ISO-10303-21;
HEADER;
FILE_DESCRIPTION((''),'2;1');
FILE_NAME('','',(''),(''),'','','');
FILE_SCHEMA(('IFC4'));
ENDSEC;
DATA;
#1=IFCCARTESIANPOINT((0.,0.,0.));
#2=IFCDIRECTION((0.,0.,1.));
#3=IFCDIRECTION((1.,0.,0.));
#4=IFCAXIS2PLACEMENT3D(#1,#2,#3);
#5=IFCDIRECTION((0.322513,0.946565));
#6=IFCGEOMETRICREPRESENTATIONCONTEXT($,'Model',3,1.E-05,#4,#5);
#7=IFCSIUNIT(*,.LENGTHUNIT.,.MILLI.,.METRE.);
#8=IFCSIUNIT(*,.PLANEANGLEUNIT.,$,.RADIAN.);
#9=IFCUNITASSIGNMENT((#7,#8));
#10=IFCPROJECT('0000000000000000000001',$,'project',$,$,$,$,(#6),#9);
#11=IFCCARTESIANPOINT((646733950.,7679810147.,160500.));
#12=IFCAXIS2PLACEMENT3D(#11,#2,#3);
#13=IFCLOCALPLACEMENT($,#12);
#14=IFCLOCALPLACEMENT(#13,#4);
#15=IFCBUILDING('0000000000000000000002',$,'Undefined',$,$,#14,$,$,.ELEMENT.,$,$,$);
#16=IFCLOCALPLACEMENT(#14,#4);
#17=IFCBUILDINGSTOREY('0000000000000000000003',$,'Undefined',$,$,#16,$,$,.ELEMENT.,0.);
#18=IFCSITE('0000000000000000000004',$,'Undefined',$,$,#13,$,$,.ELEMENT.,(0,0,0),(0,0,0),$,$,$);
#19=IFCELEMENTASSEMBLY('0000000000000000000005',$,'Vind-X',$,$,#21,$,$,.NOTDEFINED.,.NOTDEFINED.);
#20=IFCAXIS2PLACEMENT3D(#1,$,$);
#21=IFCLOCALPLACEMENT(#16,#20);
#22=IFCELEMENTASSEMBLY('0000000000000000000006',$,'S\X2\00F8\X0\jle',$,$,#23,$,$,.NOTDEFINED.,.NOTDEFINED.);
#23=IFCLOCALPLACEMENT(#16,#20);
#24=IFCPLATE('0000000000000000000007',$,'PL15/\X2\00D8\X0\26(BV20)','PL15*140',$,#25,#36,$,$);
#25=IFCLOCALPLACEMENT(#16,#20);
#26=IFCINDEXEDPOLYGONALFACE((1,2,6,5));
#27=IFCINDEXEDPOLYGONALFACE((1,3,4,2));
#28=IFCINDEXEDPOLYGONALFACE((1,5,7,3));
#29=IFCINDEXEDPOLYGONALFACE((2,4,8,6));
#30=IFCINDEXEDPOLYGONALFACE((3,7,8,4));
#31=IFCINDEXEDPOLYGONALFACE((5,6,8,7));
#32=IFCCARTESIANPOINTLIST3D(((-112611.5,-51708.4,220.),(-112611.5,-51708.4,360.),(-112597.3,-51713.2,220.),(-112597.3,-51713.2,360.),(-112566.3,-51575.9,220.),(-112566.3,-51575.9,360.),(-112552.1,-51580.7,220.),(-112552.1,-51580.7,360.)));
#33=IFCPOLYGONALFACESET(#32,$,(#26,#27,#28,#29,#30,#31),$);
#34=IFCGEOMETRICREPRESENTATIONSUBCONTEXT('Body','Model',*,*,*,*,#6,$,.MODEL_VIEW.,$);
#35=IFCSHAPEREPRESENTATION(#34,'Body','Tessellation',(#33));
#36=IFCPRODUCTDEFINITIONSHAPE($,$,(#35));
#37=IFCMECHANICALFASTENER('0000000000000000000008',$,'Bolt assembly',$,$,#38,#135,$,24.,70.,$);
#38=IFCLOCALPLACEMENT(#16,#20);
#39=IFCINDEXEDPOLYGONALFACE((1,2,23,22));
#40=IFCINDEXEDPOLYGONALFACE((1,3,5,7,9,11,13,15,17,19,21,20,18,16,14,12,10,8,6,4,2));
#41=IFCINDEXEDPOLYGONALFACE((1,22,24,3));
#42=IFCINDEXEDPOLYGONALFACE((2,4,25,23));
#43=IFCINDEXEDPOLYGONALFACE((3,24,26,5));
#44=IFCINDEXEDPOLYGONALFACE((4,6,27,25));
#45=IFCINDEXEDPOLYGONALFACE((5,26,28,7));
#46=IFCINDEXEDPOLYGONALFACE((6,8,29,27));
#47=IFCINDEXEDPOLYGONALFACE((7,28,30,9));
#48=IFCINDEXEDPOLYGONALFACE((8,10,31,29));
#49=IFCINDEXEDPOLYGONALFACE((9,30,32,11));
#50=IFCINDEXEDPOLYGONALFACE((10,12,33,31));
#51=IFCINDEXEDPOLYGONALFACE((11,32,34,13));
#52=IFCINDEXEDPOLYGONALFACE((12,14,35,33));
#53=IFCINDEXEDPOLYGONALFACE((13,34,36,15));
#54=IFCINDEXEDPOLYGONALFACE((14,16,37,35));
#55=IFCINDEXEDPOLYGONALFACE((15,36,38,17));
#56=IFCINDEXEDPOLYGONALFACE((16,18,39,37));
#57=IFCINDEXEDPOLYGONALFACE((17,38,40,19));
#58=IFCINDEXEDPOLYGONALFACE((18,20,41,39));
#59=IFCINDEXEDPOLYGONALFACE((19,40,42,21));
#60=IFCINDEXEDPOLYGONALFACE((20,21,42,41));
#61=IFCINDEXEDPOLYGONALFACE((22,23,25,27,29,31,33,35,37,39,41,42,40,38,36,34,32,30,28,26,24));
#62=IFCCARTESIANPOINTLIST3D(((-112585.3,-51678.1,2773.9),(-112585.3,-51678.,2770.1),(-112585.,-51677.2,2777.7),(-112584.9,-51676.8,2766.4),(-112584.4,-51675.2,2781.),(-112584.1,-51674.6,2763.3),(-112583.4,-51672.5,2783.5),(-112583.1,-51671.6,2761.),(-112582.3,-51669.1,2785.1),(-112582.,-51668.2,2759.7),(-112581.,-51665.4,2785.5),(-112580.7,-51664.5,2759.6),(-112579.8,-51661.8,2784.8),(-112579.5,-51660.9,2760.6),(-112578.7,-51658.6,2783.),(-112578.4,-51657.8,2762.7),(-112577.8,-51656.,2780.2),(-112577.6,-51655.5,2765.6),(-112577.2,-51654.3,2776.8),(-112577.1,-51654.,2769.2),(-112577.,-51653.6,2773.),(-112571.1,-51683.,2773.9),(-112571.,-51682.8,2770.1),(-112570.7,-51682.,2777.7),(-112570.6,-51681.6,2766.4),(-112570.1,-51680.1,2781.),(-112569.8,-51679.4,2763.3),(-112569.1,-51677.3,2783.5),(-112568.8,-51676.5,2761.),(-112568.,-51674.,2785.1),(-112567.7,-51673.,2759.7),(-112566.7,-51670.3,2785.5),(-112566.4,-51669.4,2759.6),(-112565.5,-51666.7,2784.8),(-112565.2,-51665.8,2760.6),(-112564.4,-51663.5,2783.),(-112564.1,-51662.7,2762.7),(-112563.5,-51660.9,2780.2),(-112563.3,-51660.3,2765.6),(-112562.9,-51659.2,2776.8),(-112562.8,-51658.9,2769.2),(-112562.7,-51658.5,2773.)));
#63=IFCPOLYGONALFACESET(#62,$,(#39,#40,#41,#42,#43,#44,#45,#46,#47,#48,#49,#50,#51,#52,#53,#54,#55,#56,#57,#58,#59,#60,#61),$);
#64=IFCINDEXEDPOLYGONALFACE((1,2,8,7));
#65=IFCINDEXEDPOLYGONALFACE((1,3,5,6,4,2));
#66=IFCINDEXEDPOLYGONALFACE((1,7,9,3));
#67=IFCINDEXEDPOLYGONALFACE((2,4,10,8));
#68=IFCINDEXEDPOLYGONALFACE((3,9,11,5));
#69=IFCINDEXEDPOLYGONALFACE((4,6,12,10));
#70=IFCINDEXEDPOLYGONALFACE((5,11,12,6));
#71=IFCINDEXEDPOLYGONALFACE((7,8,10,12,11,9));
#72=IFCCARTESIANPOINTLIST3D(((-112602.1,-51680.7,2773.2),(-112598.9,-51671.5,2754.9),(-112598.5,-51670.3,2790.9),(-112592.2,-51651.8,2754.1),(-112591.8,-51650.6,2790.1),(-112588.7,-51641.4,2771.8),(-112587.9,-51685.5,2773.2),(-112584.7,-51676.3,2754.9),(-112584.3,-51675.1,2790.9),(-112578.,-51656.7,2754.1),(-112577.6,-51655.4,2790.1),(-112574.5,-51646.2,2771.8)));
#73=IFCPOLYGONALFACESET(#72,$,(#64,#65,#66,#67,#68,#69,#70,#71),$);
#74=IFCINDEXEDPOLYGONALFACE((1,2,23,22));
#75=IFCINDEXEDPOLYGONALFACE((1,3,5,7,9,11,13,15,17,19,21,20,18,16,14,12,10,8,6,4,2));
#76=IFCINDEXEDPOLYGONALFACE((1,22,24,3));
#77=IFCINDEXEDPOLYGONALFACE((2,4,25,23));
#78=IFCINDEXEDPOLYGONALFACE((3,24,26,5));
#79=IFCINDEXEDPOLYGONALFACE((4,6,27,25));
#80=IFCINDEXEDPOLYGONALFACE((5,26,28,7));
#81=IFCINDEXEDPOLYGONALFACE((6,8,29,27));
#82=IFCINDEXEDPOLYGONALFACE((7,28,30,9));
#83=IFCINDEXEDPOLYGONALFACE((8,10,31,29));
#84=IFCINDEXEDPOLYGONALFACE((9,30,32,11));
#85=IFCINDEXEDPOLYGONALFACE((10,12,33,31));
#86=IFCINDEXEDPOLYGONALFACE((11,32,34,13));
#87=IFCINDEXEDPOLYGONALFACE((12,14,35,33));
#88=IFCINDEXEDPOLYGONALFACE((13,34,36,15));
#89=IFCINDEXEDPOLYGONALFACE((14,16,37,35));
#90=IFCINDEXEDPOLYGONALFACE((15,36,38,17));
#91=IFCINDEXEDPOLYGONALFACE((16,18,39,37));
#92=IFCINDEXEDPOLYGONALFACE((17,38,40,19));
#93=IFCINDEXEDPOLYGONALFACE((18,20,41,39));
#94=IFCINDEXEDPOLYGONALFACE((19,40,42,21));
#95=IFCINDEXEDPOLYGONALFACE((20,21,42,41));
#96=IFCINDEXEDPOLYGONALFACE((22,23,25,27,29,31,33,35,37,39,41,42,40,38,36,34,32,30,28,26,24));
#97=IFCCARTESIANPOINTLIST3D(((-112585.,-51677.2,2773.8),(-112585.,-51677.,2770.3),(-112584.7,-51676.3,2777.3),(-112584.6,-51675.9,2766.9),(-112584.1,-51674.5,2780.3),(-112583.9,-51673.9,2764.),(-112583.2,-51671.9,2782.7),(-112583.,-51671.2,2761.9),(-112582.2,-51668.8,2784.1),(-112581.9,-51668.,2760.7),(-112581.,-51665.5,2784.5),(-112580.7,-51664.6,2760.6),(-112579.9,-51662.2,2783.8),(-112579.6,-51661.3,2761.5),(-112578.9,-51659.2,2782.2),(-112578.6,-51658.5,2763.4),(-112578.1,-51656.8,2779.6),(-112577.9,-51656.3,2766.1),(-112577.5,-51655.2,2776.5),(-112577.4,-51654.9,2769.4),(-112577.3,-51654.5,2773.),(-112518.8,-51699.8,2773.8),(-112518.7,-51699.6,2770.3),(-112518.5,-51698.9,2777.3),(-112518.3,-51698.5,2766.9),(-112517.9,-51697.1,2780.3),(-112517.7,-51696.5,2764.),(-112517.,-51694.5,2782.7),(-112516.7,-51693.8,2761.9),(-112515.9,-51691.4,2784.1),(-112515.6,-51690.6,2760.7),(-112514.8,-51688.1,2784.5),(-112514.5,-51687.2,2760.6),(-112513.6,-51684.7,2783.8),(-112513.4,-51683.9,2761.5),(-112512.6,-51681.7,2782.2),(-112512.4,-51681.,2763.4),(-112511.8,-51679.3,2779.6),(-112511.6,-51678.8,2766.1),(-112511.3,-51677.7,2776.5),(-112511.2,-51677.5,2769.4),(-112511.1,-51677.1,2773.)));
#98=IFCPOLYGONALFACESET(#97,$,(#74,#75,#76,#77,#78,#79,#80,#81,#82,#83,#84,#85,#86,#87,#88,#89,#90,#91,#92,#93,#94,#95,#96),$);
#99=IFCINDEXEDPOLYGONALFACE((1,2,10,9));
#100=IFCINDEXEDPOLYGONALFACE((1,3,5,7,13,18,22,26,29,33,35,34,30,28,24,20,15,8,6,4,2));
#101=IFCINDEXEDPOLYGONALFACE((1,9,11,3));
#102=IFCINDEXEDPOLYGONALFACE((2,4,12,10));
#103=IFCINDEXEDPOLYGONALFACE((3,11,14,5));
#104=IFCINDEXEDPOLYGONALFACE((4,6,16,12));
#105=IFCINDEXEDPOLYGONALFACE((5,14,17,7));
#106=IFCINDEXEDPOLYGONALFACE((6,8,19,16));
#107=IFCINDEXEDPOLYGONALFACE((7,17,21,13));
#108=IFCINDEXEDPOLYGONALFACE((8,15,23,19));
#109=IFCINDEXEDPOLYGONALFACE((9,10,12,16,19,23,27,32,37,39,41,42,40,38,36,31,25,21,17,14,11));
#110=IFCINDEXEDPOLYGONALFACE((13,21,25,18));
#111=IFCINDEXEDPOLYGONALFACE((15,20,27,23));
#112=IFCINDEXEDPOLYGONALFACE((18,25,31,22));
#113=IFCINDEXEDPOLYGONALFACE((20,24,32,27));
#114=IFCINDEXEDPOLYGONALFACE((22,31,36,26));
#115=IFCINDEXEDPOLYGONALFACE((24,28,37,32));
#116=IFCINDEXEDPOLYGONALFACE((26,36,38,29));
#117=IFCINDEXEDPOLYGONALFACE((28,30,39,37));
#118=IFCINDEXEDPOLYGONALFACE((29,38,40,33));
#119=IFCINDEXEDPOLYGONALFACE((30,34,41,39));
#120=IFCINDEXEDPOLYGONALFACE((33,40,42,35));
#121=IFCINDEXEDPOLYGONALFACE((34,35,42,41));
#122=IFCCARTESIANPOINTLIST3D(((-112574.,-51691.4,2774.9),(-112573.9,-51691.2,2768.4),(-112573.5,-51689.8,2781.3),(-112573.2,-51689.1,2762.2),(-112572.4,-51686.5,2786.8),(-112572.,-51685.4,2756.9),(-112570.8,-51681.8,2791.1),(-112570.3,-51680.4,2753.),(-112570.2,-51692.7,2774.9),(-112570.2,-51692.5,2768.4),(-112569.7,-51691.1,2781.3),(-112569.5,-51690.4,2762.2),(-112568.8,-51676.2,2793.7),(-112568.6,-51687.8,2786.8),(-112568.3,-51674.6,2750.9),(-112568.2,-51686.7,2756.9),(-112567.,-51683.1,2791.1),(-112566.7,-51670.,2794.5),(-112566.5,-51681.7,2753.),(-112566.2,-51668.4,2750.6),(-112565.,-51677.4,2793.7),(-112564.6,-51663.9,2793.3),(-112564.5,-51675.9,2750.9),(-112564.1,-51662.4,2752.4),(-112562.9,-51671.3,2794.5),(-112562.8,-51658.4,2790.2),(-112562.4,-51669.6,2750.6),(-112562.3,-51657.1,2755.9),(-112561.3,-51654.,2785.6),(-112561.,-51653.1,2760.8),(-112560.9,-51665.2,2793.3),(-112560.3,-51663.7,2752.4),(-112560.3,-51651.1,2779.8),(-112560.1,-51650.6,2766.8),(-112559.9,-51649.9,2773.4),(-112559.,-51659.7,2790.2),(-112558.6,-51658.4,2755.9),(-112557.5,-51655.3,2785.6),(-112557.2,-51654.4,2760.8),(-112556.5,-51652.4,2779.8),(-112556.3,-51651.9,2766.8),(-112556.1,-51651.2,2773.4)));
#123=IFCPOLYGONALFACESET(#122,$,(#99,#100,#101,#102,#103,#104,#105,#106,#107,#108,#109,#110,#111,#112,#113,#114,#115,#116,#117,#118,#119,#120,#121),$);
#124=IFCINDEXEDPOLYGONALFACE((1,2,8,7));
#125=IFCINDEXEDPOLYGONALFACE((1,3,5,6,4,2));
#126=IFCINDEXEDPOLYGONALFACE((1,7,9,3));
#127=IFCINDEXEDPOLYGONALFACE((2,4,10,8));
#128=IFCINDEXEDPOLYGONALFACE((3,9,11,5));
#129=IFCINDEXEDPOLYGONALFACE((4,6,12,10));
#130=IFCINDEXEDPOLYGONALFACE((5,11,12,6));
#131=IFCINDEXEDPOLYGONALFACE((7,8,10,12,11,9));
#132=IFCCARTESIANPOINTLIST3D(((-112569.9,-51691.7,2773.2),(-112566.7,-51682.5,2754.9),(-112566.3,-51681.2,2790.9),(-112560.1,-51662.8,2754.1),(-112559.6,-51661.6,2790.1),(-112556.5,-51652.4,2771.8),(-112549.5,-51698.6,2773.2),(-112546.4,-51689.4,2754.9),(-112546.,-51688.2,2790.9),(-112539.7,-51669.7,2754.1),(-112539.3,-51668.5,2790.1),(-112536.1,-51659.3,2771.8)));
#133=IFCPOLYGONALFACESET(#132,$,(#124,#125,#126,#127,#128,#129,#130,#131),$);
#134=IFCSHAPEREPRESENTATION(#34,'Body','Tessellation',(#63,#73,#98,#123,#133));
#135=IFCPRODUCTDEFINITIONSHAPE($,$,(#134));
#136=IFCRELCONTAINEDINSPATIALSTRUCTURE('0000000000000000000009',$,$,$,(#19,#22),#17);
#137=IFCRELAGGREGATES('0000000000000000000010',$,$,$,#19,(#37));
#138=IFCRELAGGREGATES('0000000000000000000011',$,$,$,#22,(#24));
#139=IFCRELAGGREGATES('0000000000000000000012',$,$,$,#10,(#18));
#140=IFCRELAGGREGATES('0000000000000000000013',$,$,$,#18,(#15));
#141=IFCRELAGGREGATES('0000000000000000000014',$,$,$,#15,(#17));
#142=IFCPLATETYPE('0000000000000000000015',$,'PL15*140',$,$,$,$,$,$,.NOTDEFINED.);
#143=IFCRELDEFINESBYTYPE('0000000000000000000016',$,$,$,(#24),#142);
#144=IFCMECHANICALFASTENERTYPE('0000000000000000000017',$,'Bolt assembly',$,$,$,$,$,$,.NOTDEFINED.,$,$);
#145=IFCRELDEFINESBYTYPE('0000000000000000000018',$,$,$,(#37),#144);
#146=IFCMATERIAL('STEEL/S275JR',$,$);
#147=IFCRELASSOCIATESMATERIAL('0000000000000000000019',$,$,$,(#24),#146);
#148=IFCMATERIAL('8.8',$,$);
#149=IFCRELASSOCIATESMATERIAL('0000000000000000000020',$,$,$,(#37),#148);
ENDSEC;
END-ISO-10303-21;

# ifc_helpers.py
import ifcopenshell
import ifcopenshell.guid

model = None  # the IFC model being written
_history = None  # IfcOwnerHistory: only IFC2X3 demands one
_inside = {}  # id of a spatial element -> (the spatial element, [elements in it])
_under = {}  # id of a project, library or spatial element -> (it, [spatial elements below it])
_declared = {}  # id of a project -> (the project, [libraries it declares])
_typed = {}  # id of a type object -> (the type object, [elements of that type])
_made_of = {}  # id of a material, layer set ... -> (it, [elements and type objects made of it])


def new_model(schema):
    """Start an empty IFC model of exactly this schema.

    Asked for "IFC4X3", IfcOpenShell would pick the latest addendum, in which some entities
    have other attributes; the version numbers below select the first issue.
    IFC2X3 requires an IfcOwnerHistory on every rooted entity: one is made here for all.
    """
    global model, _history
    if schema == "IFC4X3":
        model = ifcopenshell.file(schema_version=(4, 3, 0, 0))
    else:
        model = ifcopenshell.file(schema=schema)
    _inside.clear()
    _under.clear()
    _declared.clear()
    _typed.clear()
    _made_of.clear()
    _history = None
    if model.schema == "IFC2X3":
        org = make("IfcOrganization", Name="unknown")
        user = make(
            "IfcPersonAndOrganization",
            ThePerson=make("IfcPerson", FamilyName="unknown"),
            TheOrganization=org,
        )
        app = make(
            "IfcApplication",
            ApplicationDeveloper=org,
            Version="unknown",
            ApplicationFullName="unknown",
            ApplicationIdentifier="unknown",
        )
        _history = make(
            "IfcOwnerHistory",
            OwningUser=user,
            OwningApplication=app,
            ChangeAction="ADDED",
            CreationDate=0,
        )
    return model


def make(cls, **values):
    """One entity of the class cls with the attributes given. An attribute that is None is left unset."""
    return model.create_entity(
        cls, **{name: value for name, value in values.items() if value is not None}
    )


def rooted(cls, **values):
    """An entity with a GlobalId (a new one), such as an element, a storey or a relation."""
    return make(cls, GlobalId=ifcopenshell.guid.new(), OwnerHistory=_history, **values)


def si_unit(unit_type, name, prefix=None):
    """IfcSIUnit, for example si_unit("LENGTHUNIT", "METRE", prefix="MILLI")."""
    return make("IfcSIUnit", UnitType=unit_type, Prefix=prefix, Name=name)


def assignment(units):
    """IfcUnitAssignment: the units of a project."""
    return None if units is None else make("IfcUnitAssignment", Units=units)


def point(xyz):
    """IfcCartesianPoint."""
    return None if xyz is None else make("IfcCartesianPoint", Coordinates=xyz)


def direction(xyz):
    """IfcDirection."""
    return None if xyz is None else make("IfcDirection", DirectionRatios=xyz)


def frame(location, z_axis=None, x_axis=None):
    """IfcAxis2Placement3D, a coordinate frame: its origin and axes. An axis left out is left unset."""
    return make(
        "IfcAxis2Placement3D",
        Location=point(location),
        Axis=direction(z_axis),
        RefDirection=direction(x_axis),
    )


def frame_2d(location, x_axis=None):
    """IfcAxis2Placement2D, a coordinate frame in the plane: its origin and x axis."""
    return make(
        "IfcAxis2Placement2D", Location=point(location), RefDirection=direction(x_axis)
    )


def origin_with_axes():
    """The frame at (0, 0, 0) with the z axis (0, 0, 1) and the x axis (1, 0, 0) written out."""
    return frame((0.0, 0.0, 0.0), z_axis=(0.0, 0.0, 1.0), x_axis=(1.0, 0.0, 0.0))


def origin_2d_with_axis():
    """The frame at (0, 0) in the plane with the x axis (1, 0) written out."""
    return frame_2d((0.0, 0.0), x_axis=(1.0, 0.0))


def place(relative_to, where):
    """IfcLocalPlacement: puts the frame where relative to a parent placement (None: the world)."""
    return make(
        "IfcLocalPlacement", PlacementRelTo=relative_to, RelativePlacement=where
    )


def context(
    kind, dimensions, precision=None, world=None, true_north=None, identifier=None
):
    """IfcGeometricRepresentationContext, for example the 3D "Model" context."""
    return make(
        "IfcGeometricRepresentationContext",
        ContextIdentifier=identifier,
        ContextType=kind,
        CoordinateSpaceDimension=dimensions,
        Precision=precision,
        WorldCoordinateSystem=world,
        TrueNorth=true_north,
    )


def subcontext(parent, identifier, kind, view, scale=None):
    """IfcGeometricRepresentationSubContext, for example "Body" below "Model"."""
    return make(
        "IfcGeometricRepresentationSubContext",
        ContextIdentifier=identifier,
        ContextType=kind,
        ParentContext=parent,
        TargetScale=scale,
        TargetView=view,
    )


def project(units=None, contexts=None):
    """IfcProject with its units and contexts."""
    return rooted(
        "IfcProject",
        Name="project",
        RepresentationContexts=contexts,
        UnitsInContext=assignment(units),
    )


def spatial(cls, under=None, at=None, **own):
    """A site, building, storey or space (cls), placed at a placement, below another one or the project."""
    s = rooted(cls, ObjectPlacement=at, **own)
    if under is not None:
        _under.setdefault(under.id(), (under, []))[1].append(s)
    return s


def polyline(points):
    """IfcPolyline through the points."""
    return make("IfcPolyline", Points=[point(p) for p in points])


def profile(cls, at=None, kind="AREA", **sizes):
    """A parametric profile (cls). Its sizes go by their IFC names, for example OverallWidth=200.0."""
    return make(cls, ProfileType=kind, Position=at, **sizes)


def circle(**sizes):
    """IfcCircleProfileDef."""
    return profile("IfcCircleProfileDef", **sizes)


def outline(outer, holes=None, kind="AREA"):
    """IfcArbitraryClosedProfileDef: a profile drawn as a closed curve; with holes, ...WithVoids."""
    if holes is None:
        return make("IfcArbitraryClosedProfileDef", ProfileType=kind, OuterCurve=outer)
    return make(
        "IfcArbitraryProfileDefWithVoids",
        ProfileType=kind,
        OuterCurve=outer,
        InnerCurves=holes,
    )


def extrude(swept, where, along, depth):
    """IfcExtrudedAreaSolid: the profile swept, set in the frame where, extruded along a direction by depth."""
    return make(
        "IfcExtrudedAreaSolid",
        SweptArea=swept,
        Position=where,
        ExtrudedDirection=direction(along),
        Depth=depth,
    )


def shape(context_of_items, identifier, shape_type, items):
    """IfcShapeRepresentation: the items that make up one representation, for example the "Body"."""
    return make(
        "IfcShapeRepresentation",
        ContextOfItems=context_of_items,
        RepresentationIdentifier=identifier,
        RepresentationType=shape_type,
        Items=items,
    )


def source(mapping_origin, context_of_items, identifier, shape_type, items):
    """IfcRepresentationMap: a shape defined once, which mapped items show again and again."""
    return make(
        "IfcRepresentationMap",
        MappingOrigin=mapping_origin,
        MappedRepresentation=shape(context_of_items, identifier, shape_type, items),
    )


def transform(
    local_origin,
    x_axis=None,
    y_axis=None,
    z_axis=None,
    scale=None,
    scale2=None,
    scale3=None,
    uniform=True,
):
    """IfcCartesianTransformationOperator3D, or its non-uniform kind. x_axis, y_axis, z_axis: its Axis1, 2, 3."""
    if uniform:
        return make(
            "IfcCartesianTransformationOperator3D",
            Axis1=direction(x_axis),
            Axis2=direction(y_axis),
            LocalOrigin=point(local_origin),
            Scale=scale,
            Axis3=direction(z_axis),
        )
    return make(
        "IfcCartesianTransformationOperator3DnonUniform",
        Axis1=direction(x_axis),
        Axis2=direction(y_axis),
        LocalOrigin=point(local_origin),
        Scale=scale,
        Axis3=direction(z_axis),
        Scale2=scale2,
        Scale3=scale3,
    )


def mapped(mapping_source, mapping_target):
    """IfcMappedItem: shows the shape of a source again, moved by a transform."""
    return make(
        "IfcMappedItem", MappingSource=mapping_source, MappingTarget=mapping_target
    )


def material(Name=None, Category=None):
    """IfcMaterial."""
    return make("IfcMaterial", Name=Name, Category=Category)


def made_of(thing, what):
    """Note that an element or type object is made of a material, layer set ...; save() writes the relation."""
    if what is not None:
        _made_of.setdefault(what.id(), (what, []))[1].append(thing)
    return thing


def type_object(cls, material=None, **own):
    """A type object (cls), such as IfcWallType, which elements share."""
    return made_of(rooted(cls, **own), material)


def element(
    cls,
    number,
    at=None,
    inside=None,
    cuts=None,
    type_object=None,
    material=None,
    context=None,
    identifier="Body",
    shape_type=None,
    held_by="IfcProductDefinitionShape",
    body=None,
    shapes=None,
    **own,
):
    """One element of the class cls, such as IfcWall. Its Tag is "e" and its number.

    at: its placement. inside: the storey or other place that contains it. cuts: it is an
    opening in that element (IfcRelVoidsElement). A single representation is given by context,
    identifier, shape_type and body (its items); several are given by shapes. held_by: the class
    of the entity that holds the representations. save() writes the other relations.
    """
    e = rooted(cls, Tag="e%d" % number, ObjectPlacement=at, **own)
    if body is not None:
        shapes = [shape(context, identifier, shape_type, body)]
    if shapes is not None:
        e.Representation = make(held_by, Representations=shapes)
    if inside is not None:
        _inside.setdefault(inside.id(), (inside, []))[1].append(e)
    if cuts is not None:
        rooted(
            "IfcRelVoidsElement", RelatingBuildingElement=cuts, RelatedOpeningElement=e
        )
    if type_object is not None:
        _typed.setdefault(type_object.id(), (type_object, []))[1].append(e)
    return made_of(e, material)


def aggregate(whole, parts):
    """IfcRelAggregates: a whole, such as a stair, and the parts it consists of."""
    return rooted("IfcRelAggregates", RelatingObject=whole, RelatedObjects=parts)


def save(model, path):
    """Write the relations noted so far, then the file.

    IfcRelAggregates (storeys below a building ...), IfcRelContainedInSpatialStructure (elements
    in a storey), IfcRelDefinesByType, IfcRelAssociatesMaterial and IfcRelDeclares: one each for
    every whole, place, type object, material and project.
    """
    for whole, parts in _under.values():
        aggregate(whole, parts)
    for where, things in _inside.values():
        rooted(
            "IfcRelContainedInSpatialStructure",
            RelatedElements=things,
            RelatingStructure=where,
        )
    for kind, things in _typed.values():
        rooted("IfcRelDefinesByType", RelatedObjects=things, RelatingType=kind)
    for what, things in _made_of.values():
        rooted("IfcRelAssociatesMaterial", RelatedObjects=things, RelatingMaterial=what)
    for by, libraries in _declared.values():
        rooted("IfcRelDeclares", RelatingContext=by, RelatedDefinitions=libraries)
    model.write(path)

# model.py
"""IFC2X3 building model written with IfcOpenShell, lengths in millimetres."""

from ifc_helpers import new_model, si_unit, direction, frame, origin_with_axes, origin_2d_with_axis, place, context, subcontext, project, spatial, polyline, circle, outline, extrude, source, transform, mapped, material, type_object, element, aggregate, save


model = new_model("IFC2X3")

# Units and contexts
model_context = context("Model", 3, precision=1e-05, world=origin_with_axes(), true_north=direction((0.322513, 0.946565)))
body_context = subcontext(model_context, "Body", "Model", "MODEL_VIEW")
ifc_project = project(units=[si_unit("LENGTHUNIT", "METRE", prefix="MILLI"), si_unit("PLANEANGLEUNIT", "RADIAN")], contexts=[model_context])

# Site, building, storey
site_placement = place(None, frame((646733950.0, 7679810147.0, 160500.0), z_axis=(0.0, 0.0, 1.0), x_axis=(1.0, 0.0, 0.0)))
site = spatial("IfcSite", under=ifc_project, at=site_placement, Name="Undefined", CompositionType="ELEMENT", RefLatitude=(0, 0, 0), RefLongitude=(0, 0, 0))
building_placement = place(site_placement, origin_with_axes())
building = spatial("IfcBuilding", under=site, at=building_placement, Name="Undefined", CompositionType="ELEMENT")
storey_placement = place(building_placement, origin_with_axes())
storey = spatial("IfcBuildingStorey", under=building, at=storey_placement, Name="Undefined", CompositionType="ELEMENT", Elevation=0.0)

# Element assembly
assembly_1_placement = place(storey_placement, origin_with_axes())
assembly_1 = element("IfcElementAssembly", 1, at=assembly_1_placement, inside=storey, Name="Vind-X", AssemblyPlace="NOTDEFINED", PredefinedType="NOTDEFINED")

# Shared definitions
ifc_material_1 = material(Name="STEEL/S275JR")

# Element assembly
assembly_2_placement = place(storey_placement, origin_with_axes())
assembly_2 = element("IfcElementAssembly", 2, at=assembly_2_placement, inside=storey, Name="Søjle", AssemblyPlace="NOTDEFINED", PredefinedType="NOTDEFINED")

# Plate
plate_type_1 = type_object("IfcPlateType", Name="PL15*140", PredefinedType="NOTDEFINED")
plate_1_placement = place(assembly_2_placement, frame((-112559.2, -51578.3, 220.0), z_axis=(-0.946565, 0.322513, 0.0), x_axis=(-0.322513, -0.946565, 0.0)))
plate_1 = element("IfcPlate", 3, at=plate_1_placement, type_object=plate_type_1, material=ifc_material_1, Name="PL15/Ø26(BV20)", Description="PL15*140", context=body_context, shape_type="SweptSolid", body=[
    extrude(outline(polyline([(0.0, 0.0), (140.0, 0.0), (140.0, 140.0), (0.0, 140.0), (0.0, 0.0)])), frame((0.0, 0.0, -7.5), z_axis=(0.0, 0.0, 1.0), x_axis=(1.0, 0.0, 0.0)), (0.0, 0.0, 1.0), 15.0),
])

# Mechanical fastener
ifc_material_2 = material(Name="8.8")
mechanical_fastener_type = type_object("IfcMechanicalFastenerType", Name="Bolt assembly")
shared_shape_1 = source(origin_with_axes(), body_context, "Body", "SweptSolid", [
    extrude(circle(Radius=13.0, at=origin_2d_with_axis()), frame((0.0, 0.0, 0.0), z_axis=(0.0, 1.0, 0.0), x_axis=(1.0, 0.0, 0.0)), (0.0, 0.0, 1.0), 15.1),
    extrude(outline(polyline([(18.0, -10.4), (18.0, 10.4), (0.0, 20.8), (-18.0, 10.4), (-18.0, -10.4), (0.0, -20.8), (18.0, -10.4)])), frame((0.0, -15.0, 0.0), z_axis=(0.0, 1.0, 0.0), x_axis=(1.0, 0.0, 0.0)), (0.0, 0.0, 1.0), 15.0),
    extrude(circle(Radius=12.0, at=origin_2d_with_axis()), frame((0.0, 0.0, 0.0), z_axis=(0.0, 1.0, 0.0), x_axis=(1.0, 0.0, 0.0)), (0.0, 0.0, 1.0), 70.0),
    extrude(circle(Radius=22.0, at=origin_2d_with_axis()), frame((0.0, 15.0, 0.0), z_axis=(0.0, 1.0, 0.0), x_axis=(1.0, 0.0, 0.0)), (0.0, 0.0, 1.0), 4.0),
    extrude(outline(polyline([(18.0, -10.4), (18.0, 10.4), (0.0, 20.8), (-18.0, 10.4), (-18.0, -10.4), (0.0, -20.8), (18.0, -10.4)])), frame((0.0, 19.0, 0.0), z_axis=(0.0, 1.0, 0.0), x_axis=(1.0, 0.0, 0.0)), (0.0, 0.0, 1.0), 21.5),
])
mechanical_fastener_1_placement = place(assembly_1_placement, frame((-112581.2, -51665.9, 2772.5), z_axis=(-0.151189, -0.443735, 0.883313), x_axis=(-0.28488, -0.836113, -0.468784)))
mechanical_fastener_1 = element("IfcMechanicalFastener", 4, at=mechanical_fastener_1_placement, type_object=mechanical_fastener_type, material=ifc_material_2, Name="Bolt assembly", NominalDiameter=24.0, NominalLength=70.0, context=body_context, shape_type="MappedRepresentation", body=[
    mapped(shared_shape_1, transform((0.0, 0.0, 0.0))),
])
aggregate(assembly_1, [mechanical_fastener_1])
aggregate(assembly_2, [plate_1])

save(model, "model.ifc")
